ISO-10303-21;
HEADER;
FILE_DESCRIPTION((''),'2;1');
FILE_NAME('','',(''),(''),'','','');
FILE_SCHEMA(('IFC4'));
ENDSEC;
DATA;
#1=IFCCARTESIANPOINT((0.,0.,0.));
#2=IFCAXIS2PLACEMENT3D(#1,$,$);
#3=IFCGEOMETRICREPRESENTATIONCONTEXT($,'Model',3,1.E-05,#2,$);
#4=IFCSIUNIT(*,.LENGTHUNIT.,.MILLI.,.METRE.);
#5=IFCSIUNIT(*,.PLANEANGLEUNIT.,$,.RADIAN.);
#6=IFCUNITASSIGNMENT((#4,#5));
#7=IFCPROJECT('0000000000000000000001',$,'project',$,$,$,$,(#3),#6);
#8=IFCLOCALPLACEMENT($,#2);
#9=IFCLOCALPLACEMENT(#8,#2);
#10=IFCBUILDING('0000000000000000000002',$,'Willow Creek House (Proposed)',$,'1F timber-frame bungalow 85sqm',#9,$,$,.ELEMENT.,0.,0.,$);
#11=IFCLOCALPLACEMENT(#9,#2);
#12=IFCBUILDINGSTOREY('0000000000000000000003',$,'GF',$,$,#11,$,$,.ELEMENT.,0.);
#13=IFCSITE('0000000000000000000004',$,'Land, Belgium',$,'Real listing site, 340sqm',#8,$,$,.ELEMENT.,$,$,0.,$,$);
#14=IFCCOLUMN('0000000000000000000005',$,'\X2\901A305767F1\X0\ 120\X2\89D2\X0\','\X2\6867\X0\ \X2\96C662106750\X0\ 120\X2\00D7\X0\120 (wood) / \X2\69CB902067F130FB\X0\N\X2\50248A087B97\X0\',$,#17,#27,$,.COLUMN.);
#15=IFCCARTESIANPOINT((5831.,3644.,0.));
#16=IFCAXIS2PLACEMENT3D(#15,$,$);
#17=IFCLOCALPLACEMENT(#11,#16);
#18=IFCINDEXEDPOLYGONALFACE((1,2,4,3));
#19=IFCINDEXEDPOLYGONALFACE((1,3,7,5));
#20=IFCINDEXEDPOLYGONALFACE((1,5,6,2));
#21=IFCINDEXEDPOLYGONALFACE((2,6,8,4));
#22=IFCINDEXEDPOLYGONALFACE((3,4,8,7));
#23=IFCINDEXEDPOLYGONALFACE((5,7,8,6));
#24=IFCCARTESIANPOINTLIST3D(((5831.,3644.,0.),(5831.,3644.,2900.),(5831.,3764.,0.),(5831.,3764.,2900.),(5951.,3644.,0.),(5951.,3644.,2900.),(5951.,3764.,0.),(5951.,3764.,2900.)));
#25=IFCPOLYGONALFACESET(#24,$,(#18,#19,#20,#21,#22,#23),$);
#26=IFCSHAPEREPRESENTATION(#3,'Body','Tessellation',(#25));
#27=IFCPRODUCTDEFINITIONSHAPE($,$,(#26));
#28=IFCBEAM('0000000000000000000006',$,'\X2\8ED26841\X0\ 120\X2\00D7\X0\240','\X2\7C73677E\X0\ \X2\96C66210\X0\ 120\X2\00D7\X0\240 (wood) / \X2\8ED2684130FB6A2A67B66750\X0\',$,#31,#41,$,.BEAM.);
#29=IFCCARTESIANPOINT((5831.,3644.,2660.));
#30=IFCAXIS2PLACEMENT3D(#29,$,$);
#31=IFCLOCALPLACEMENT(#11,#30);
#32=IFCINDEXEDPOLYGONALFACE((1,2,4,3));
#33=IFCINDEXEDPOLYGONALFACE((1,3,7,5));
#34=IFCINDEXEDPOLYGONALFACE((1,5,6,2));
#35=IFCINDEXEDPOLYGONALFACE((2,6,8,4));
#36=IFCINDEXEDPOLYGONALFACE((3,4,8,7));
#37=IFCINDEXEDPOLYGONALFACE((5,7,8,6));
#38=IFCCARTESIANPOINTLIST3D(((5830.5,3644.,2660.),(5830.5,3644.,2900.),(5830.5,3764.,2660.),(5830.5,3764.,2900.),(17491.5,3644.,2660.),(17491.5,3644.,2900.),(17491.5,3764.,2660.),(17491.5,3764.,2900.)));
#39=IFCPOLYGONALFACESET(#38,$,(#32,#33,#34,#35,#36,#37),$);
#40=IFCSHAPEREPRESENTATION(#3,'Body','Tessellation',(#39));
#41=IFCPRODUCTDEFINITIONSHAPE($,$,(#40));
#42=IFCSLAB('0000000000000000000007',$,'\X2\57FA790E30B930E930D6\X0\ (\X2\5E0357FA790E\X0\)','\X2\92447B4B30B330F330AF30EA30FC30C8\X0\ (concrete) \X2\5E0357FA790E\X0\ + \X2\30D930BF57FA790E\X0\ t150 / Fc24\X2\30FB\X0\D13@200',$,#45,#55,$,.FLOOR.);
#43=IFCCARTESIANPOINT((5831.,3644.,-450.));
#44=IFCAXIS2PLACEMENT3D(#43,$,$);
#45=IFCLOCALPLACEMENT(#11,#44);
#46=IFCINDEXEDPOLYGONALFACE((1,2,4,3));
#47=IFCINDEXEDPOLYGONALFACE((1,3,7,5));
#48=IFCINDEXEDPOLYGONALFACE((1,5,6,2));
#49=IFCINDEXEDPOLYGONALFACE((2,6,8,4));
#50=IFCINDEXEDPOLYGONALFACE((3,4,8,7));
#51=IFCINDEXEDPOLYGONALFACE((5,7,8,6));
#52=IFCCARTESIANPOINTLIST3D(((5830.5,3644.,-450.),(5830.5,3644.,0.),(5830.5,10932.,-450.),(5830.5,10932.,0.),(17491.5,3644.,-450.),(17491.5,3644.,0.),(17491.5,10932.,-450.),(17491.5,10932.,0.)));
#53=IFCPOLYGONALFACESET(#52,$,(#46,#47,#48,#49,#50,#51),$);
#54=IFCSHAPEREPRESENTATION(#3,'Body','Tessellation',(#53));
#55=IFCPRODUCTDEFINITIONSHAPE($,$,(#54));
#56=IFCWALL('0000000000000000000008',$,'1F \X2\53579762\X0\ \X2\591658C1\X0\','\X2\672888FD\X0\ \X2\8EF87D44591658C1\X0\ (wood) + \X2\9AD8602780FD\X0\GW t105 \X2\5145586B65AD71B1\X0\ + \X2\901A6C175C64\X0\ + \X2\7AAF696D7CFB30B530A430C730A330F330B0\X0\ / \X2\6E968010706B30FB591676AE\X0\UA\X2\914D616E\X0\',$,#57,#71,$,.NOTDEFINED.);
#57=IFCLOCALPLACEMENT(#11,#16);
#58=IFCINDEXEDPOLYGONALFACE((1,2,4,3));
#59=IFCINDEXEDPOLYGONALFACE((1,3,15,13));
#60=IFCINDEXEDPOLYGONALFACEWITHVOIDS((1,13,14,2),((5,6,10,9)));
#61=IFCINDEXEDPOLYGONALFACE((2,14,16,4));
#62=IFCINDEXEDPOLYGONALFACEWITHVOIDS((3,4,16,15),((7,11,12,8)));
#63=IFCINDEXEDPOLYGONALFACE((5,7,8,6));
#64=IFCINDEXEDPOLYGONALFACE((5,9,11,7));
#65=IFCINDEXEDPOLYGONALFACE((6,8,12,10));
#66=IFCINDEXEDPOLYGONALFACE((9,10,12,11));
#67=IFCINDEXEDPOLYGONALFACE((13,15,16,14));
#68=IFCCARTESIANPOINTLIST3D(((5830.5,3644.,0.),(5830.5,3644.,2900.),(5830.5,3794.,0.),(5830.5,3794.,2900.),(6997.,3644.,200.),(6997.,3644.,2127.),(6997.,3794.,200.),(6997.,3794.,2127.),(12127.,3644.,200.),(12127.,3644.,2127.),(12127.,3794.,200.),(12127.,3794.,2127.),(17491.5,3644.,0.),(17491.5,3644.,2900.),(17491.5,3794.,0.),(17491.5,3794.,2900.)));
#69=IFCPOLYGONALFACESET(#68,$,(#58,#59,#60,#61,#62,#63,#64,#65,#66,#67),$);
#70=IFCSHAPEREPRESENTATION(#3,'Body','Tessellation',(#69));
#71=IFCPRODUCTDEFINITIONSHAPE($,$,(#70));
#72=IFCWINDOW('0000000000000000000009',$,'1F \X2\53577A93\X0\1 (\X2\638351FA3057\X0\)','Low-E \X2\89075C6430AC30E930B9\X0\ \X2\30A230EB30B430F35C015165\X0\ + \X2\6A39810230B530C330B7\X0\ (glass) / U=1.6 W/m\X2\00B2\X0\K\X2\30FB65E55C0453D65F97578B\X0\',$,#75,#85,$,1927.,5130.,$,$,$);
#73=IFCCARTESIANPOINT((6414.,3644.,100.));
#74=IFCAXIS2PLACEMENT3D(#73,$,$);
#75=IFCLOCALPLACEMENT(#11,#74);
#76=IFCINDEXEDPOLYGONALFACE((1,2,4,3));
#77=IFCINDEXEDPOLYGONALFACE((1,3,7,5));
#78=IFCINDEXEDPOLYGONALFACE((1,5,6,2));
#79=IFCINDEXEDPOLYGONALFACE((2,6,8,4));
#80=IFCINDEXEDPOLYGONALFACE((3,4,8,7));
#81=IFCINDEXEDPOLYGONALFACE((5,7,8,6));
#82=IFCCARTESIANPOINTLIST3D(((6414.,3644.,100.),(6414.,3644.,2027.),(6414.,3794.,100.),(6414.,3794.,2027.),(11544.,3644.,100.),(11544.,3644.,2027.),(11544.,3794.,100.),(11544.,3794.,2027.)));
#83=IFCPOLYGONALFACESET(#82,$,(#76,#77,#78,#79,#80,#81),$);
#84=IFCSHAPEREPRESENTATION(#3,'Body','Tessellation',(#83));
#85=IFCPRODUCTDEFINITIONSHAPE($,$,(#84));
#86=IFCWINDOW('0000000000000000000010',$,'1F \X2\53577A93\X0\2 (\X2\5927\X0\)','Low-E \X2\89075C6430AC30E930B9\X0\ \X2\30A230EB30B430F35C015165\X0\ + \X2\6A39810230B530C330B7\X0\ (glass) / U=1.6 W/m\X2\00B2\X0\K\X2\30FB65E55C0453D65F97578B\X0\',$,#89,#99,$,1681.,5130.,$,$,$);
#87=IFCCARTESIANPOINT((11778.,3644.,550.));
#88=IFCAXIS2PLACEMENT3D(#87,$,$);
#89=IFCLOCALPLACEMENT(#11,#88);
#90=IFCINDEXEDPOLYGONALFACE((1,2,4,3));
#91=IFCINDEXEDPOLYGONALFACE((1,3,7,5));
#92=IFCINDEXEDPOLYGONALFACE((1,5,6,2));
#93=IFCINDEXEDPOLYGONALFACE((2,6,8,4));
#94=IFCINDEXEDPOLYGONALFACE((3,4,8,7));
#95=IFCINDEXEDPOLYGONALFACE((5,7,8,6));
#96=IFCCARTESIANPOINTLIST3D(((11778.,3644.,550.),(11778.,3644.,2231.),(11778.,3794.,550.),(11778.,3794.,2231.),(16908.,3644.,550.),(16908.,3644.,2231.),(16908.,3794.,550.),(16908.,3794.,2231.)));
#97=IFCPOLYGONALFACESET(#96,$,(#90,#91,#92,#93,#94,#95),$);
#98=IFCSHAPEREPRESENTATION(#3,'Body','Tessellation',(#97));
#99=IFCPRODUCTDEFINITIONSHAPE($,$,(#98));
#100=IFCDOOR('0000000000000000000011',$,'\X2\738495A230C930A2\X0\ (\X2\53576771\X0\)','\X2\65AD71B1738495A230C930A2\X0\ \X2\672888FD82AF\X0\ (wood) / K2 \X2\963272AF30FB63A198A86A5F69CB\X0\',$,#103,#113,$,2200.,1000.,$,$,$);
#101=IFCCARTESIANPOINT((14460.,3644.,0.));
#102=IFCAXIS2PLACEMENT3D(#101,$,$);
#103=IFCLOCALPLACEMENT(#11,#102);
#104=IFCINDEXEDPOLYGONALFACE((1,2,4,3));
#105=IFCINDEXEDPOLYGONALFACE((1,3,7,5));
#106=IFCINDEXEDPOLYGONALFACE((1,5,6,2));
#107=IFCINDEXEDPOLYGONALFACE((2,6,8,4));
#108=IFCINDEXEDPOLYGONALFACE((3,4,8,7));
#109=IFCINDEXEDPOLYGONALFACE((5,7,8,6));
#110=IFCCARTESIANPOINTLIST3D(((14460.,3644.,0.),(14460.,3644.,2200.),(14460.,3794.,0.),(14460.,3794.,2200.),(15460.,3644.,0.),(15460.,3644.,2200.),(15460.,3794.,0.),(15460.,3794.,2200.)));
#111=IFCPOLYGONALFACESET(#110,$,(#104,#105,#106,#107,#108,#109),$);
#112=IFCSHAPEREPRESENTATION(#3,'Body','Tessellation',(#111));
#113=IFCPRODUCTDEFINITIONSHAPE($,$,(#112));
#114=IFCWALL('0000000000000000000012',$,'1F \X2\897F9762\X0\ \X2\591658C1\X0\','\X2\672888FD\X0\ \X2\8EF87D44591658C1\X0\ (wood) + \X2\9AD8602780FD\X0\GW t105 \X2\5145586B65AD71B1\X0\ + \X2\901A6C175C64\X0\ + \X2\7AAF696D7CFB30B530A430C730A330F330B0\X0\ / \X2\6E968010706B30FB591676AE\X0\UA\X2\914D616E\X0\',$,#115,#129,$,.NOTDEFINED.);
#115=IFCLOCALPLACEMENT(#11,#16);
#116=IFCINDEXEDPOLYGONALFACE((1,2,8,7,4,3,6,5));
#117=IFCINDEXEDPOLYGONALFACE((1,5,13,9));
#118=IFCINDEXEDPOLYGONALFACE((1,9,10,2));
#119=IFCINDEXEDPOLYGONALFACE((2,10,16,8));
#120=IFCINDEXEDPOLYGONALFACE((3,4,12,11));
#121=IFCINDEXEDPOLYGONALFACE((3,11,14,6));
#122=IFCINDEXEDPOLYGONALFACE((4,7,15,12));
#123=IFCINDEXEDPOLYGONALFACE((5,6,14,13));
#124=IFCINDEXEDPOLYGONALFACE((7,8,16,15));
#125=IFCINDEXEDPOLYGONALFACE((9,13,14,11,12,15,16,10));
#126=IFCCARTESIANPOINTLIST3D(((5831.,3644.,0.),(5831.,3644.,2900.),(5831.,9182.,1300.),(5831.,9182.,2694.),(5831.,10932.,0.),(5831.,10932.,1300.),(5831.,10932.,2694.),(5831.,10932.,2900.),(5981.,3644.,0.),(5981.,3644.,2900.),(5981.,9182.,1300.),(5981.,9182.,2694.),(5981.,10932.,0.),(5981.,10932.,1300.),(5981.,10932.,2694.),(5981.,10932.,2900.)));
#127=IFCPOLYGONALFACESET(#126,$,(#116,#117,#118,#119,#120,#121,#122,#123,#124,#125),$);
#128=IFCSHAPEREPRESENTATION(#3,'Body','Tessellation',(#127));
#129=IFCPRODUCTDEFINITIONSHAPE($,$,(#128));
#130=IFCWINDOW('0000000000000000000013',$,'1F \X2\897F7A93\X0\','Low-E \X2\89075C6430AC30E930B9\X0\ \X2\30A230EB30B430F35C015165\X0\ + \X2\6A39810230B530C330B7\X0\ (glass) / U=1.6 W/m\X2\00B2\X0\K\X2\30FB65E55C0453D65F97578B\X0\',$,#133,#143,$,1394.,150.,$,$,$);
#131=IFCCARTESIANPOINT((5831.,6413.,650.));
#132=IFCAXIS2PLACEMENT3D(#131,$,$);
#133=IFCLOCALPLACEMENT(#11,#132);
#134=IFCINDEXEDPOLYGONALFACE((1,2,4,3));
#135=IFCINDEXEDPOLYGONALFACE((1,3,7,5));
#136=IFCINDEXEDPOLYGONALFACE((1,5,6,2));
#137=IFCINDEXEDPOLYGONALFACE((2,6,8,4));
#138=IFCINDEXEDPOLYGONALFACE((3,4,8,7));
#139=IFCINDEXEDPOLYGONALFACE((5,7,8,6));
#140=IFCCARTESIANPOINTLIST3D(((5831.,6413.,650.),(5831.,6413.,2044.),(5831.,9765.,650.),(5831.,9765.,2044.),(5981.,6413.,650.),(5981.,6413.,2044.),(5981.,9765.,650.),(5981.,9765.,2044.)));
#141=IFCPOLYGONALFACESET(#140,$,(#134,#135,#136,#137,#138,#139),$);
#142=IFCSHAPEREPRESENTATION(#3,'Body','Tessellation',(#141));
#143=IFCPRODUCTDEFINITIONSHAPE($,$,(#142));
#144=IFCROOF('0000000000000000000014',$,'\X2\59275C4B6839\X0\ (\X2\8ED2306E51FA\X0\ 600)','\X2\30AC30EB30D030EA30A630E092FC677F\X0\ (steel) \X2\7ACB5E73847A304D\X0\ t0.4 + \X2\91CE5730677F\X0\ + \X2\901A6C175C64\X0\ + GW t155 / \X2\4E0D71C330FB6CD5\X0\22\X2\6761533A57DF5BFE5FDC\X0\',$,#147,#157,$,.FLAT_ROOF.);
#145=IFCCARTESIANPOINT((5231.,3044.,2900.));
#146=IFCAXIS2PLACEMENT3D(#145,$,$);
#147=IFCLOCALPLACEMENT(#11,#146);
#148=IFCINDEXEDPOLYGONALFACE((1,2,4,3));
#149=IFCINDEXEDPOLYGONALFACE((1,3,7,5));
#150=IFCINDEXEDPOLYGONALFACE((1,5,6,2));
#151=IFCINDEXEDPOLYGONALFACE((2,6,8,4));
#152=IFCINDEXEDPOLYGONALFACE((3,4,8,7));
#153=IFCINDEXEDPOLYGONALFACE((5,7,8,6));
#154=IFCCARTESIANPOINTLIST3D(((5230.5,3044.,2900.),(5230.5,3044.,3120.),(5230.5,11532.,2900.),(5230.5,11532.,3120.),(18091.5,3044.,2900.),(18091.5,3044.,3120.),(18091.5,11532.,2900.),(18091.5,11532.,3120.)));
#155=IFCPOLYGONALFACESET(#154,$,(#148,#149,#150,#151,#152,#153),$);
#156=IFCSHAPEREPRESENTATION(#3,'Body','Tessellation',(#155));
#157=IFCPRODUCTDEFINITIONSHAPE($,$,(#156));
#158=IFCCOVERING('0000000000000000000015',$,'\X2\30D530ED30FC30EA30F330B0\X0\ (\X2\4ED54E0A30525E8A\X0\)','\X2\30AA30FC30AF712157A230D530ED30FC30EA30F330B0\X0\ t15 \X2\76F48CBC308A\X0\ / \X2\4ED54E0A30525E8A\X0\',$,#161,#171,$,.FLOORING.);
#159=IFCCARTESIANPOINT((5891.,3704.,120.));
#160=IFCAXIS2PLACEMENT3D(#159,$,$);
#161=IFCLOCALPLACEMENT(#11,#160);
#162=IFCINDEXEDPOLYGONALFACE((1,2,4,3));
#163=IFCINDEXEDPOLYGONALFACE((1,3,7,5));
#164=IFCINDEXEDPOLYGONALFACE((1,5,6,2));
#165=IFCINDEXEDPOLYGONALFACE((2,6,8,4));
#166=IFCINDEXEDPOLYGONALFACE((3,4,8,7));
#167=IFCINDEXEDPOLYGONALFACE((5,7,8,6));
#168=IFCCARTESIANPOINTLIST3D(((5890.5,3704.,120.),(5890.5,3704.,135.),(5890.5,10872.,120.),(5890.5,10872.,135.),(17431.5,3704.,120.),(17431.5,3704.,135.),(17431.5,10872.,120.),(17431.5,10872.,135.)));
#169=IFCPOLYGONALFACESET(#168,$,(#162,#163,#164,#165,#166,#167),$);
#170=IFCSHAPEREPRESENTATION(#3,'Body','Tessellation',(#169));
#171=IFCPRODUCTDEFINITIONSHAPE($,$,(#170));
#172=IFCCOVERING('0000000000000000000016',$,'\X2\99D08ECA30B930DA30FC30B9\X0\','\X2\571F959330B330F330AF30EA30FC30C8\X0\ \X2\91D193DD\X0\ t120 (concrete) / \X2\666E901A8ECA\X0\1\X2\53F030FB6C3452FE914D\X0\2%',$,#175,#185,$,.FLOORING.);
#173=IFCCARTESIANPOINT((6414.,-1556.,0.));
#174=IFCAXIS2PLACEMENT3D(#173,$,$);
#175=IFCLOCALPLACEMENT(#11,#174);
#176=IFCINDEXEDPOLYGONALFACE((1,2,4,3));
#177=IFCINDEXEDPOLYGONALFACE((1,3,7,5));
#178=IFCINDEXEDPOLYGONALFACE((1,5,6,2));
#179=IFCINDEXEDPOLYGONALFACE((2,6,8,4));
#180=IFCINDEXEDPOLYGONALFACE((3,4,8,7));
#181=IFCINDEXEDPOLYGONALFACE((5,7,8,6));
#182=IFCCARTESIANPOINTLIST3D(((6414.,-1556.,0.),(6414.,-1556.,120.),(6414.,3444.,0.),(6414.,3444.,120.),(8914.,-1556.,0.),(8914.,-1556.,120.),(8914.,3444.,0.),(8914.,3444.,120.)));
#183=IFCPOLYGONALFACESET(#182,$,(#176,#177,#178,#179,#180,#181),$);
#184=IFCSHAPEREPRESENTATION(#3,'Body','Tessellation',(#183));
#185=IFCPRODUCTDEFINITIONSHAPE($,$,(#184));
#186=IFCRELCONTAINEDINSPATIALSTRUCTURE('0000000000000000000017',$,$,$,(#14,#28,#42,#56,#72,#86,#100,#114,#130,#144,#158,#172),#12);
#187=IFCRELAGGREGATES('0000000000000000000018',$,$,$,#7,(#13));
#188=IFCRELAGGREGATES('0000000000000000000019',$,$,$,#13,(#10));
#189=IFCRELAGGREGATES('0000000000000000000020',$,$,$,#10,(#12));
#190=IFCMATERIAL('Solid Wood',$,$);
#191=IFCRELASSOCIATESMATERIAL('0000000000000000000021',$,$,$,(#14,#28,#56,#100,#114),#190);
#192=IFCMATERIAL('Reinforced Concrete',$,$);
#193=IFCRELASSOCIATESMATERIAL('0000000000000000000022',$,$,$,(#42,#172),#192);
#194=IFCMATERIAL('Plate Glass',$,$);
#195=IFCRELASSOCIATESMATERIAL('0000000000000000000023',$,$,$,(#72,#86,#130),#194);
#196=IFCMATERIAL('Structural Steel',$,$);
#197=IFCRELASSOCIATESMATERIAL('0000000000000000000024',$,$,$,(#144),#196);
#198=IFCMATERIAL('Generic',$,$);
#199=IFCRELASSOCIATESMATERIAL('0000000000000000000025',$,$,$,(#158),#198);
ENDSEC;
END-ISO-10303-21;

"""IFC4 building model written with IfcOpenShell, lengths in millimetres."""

from ifc_helpers import new_model, si_unit, frame, frame_2d, origin, place, context, project, spatial, rectangle, extrude, material, element, fill, save


model = new_model("IFC4")

# Units and contexts
model_context = context("Model", 3, precision=1e-05, world=origin())
ifc_project = project(units=[si_unit("LENGTHUNIT", "METRE", prefix="MILLI"), si_unit("PLANEANGLEUNIT", "RADIAN")], contexts=[model_context])

# Site, building, storey
site_placement = place(None, origin())
site = spatial("IfcSite", under=ifc_project, at=site_placement, Name="Land, Belgium", ObjectType="Real listing site, 340sqm", CompositionType="ELEMENT", RefElevation=0.0)
building_placement = place(site_placement, origin())
building = spatial("IfcBuilding", under=site, at=building_placement, Name="Willow Creek House (Proposed)", ObjectType="1F timber-frame bungalow 85sqm", CompositionType="ELEMENT", ElevationOfRefHeight=0.0, ElevationOfTerrain=0.0)
storey_placement = place(building_placement, origin())
storey = spatial("IfcBuildingStorey", under=building, at=storey_placement, Name="GF", CompositionType="ELEMENT", Elevation=0.0)

# Column
ifc_material_1 = material(Name="Solid Wood")
column_1_placement = place(storey_placement, frame((5831.0, 3644.0, 0.0)))
element("IfcColumn", 1, at=column_1_placement, inside=storey, material=ifc_material_1, Name="通し柱 120角", Description="桧 集成材 120×120 (wood) / 構造柱・N値計算", PredefinedType="COLUMN", context=model_context, shape_type="SweptSolid", body=[
    extrude(rectangle(XDim=120.0, YDim=120.0, at=frame_2d((60.0, 60.0))), frame((5831.0, 3644.0, 0.0)), (0.0, 0.0, 1.0), 2900.0),
])

# Beam
beam_1_placement = place(storey_placement, frame((5831.0, 3644.0, 2660.0)))
element("IfcBeam", 2, at=beam_1_placement, inside=storey, material=ifc_material_1, Name="軒桁 120×240", Description="米松 集成 120×240 (wood) / 軒桁・横架材", PredefinedType="BEAM", context=model_context, shape_type="SweptSolid", body=[
    extrude(rectangle(XDim=11661.0, YDim=120.0, at=frame_2d((5830.0, 60.0))), frame((5831.0, 3644.0, 2660.0)), (0.0, 0.0, 1.0), 240.0),
])

# Slab
ifc_material_2 = material(Name="Reinforced Concrete")
slab_1_placement = place(storey_placement, frame((5831.0, 3644.0, -450.0)))
element("IfcSlab", 3, at=slab_1_placement, inside=storey, material=ifc_material_2, Name="基礎スラブ (布基礎)", Description="鉄筋コンクリート (concrete) 布基礎 + ベタ基礎 t150 / Fc24・D13@200", PredefinedType="FLOOR", context=model_context, shape_type="SweptSolid", body=[
    extrude(rectangle(XDim=11661.0, YDim=7288.0, at=frame_2d((5830.0, 3644.0))), frame((5831.0, 3644.0, -450.0)), (0.0, 0.0, 1.0), 450.0),
])

# Wall, openings, windows, door
wall_1_placement = place(storey_placement, frame((5831.0, 3644.0, 0.0)))
wall_1 = element("IfcWall", 4, at=wall_1_placement, inside=storey, material=ifc_material_1, Name="1F 南面 外壁", Description="木製 軸組外壁 (wood) + 高性能GW t105 充填断熱 + 通気層 + 窯業系サイディング / 準耐火・外皮UA配慮", PredefinedType="NOTDEFINED", context=model_context, shape_type="SweptSolid", body=[
    extrude(rectangle(XDim=11661.0, YDim=150.0, at=frame_2d((5830.0, 75.0))), frame((5831.0, 3644.0, 0.0)), (0.0, 0.0, 1.0), 2900.0),
])
opening_1_placement = place(storey_placement, frame((6414.0, 3644.0, 100.0)))
opening_1 = element("IfcOpeningElement", 5, at=opening_1_placement, cuts=wall_1, PredefinedType="NOTDEFINED", context=model_context, shape_type="SweptSolid", body=[
    extrude(rectangle(XDim=5130.0, YDim=150.0, at=frame_2d((2565.0, 75.0))), frame((6414.0, 3644.0, 100.0)), (0.0, 0.0, 1.0), 1927.0),
])
opening_2_placement = place(storey_placement, frame((11778.0, 3644.0, 550.0)))
opening_2 = element("IfcOpeningElement", 6, at=opening_2_placement, cuts=wall_1, PredefinedType="NOTDEFINED", context=model_context, shape_type="SweptSolid", body=[
    extrude(rectangle(XDim=5130.0, YDim=150.0, at=frame_2d((2565.0, 75.0))), frame((11778.0, 3644.0, 550.0)), (0.0, 0.0, 1.0), 1681.0),
])
opening_3_placement = place(storey_placement, frame((14460.0, 3644.0, 0.0)))
opening_3 = element("IfcOpeningElement", 7, at=opening_3_placement, cuts=wall_1, PredefinedType="NOTDEFINED", context=model_context, shape_type="SweptSolid", body=[
    extrude(rectangle(XDim=1000.0, YDim=150.0, at=frame_2d((500.0, 75.0))), frame((14460.0, 3644.0, 0.0)), (0.0, 0.0, 1.0), 2200.0),
])
ifc_material_3 = material(Name="Plate Glass")
window_1_placement = place(storey_placement, frame((6414.0, 3644.0, 100.0)))
window_1 = element("IfcWindow", 8, at=window_1_placement, inside=storey, material=ifc_material_3, Name="1F 南窓1 (掃出し)", Description="Low-E 複層ガラス アルゴン封入 + 樹脂サッシ (glass) / U=1.6 W/m²K・日射取得型", OverallHeight=1927.0, OverallWidth=5130.0, context=model_context, shape_type="SweptSolid", body=[
    extrude(rectangle(XDim=5130.0, YDim=150.0, at=frame_2d((2565.0, 75.0))), frame((6414.0, 3644.0, 100.0)), (0.0, 0.0, 1.0), 1927.0),
])
fill(opening_1, window_1)
window_2_placement = place(storey_placement, frame((11778.0, 3644.0, 550.0)))
window_2 = element("IfcWindow", 9, at=window_2_placement, inside=storey, material=ifc_material_3, Name="1F 南窓2 (大)", Description="Low-E 複層ガラス アルゴン封入 + 樹脂サッシ (glass) / U=1.6 W/m²K・日射取得型", OverallHeight=1681.0, OverallWidth=5130.0, context=model_context, shape_type="SweptSolid", body=[
    extrude(rectangle(XDim=5130.0, YDim=150.0, at=frame_2d((2565.0, 75.0))), frame((11778.0, 3644.0, 550.0)), (0.0, 0.0, 1.0), 1681.0),
])
fill(opening_2, window_2)
door_placement = place(storey_placement, frame((14460.0, 3644.0, 0.0)))
door = element("IfcDoor", 10, at=door_placement, inside=storey, material=ifc_material_1, Name="玄関ドア (南東)", Description="断熱玄関ドア 木製芯 (wood) / K2 防犯・採風機構", OverallHeight=2200.0, OverallWidth=1000.0, context=model_context, shape_type="SweptSolid", body=[
    extrude(rectangle(XDim=1000.0, YDim=150.0, at=frame_2d((500.0, 75.0))), frame((14460.0, 3644.0, 0.0)), (0.0, 0.0, 1.0), 2200.0),
])
fill(opening_3, door)

# Wall, opening, window
wall_2_placement = place(storey_placement, frame((5831.0, 3644.0, 0.0)))
wall_2 = element("IfcWall", 11, at=wall_2_placement, inside=storey, material=ifc_material_1, Name="1F 西面 外壁", Description="木製 軸組外壁 (wood) + 高性能GW t105 充填断熱 + 通気層 + 窯業系サイディング / 準耐火・外皮UA配慮", PredefinedType="NOTDEFINED", context=model_context, shape_type="SweptSolid", body=[
    extrude(rectangle(XDim=150.0, YDim=7288.0, at=frame_2d((75.0, 3644.0))), frame((5831.0, 3644.0, 0.0)), (0.0, 0.0, 1.0), 2900.0),
])
opening_4_placement = place(storey_placement, frame((5831.0, 6413.0, 650.0)))
opening_4 = element("IfcOpeningElement", 12, at=opening_4_placement, cuts=wall_2, PredefinedType="NOTDEFINED", context=model_context, shape_type="SweptSolid", body=[
    extrude(rectangle(XDim=150.0, YDim=3352.0, at=frame_2d((75.0, 1676.0))), frame((5831.0, 6413.0, 650.0)), (0.0, 0.0, 1.0), 1394.0),
])
window_3_placement = place(storey_placement, frame((5831.0, 6413.0, 650.0)))
window_3 = element("IfcWindow", 13, at=window_3_placement, inside=storey, material=ifc_material_3, Name="1F 西窓", Description="Low-E 複層ガラス アルゴン封入 + 樹脂サッシ (glass) / U=1.6 W/m²K・日射取得型", OverallHeight=1394.0, OverallWidth=150.0, context=model_context, shape_type="SweptSolid", body=[
    extrude(rectangle(XDim=150.0, YDim=3352.0, at=frame_2d((75.0, 1676.0))), frame((5831.0, 6413.0, 650.0)), (0.0, 0.0, 1.0), 1394.0),
])
fill(opening_4, window_3)

# Roof
ifc_material_4 = material(Name="Structural Steel")
roof_placement = place(storey_placement, frame((5231.0, 3044.0, 2900.0)))
element("IfcRoof", 14, at=roof_placement, inside=storey, material=ifc_material_4, Name="大屋根 (軒の出 600)", Description="ガルバリウム鋼板 (steel) 立平葺き t0.4 + 野地板 + 通気層 + GW t155 / 不燃・法22条区域対応", PredefinedType="FLAT_ROOF", context=model_context, shape_type="SweptSolid", body=[
    extrude(rectangle(XDim=12861.0, YDim=8488.0, at=frame_2d((6430.0, 4244.0))), frame((5231.0, 3044.0, 2900.0)), (0.0, 0.0, 1.0), 220.0),
])

# Coverings
ifc_material_5 = material(Name="Generic")
covering_1_placement = place(storey_placement, frame((5891.0, 3704.0, 120.0)))
element("IfcCovering", 15, at=covering_1_placement, inside=storey, material=ifc_material_5, Name="フローリング (仕上げ床)", Description="オーク無垢フローリング t15 直貼り / 仕上げ床", PredefinedType="FLOORING", context=model_context, shape_type="SweptSolid", body=[
    extrude(rectangle(XDim=11541.0, YDim=7168.0, at=frame_2d((5770.0, 3584.0))), frame((5891.0, 3704.0, 120.0)), (0.0, 0.0, 1.0), 15.0),
])
covering_2_placement = place(storey_placement, frame((6414.0, -1556.0, 0.0)))
element("IfcCovering", 16, at=covering_2_placement, inside=storey, material=ifc_material_2, Name="駐車スペース", Description="土間コンクリート 金鏝 t120 (concrete) / 普通車1台・水勾配2%", PredefinedType="FLOORING", context=model_context, shape_type="SweptSolid", body=[
    extrude(rectangle(XDim=2500.0, YDim=5000.0, at=frame_2d((1250.0, 2500.0))), frame((6414.0, -1556.0, 0.0)), (0.0, 0.0, 1.0), 120.0),
])

save(model, "model.ifc")
